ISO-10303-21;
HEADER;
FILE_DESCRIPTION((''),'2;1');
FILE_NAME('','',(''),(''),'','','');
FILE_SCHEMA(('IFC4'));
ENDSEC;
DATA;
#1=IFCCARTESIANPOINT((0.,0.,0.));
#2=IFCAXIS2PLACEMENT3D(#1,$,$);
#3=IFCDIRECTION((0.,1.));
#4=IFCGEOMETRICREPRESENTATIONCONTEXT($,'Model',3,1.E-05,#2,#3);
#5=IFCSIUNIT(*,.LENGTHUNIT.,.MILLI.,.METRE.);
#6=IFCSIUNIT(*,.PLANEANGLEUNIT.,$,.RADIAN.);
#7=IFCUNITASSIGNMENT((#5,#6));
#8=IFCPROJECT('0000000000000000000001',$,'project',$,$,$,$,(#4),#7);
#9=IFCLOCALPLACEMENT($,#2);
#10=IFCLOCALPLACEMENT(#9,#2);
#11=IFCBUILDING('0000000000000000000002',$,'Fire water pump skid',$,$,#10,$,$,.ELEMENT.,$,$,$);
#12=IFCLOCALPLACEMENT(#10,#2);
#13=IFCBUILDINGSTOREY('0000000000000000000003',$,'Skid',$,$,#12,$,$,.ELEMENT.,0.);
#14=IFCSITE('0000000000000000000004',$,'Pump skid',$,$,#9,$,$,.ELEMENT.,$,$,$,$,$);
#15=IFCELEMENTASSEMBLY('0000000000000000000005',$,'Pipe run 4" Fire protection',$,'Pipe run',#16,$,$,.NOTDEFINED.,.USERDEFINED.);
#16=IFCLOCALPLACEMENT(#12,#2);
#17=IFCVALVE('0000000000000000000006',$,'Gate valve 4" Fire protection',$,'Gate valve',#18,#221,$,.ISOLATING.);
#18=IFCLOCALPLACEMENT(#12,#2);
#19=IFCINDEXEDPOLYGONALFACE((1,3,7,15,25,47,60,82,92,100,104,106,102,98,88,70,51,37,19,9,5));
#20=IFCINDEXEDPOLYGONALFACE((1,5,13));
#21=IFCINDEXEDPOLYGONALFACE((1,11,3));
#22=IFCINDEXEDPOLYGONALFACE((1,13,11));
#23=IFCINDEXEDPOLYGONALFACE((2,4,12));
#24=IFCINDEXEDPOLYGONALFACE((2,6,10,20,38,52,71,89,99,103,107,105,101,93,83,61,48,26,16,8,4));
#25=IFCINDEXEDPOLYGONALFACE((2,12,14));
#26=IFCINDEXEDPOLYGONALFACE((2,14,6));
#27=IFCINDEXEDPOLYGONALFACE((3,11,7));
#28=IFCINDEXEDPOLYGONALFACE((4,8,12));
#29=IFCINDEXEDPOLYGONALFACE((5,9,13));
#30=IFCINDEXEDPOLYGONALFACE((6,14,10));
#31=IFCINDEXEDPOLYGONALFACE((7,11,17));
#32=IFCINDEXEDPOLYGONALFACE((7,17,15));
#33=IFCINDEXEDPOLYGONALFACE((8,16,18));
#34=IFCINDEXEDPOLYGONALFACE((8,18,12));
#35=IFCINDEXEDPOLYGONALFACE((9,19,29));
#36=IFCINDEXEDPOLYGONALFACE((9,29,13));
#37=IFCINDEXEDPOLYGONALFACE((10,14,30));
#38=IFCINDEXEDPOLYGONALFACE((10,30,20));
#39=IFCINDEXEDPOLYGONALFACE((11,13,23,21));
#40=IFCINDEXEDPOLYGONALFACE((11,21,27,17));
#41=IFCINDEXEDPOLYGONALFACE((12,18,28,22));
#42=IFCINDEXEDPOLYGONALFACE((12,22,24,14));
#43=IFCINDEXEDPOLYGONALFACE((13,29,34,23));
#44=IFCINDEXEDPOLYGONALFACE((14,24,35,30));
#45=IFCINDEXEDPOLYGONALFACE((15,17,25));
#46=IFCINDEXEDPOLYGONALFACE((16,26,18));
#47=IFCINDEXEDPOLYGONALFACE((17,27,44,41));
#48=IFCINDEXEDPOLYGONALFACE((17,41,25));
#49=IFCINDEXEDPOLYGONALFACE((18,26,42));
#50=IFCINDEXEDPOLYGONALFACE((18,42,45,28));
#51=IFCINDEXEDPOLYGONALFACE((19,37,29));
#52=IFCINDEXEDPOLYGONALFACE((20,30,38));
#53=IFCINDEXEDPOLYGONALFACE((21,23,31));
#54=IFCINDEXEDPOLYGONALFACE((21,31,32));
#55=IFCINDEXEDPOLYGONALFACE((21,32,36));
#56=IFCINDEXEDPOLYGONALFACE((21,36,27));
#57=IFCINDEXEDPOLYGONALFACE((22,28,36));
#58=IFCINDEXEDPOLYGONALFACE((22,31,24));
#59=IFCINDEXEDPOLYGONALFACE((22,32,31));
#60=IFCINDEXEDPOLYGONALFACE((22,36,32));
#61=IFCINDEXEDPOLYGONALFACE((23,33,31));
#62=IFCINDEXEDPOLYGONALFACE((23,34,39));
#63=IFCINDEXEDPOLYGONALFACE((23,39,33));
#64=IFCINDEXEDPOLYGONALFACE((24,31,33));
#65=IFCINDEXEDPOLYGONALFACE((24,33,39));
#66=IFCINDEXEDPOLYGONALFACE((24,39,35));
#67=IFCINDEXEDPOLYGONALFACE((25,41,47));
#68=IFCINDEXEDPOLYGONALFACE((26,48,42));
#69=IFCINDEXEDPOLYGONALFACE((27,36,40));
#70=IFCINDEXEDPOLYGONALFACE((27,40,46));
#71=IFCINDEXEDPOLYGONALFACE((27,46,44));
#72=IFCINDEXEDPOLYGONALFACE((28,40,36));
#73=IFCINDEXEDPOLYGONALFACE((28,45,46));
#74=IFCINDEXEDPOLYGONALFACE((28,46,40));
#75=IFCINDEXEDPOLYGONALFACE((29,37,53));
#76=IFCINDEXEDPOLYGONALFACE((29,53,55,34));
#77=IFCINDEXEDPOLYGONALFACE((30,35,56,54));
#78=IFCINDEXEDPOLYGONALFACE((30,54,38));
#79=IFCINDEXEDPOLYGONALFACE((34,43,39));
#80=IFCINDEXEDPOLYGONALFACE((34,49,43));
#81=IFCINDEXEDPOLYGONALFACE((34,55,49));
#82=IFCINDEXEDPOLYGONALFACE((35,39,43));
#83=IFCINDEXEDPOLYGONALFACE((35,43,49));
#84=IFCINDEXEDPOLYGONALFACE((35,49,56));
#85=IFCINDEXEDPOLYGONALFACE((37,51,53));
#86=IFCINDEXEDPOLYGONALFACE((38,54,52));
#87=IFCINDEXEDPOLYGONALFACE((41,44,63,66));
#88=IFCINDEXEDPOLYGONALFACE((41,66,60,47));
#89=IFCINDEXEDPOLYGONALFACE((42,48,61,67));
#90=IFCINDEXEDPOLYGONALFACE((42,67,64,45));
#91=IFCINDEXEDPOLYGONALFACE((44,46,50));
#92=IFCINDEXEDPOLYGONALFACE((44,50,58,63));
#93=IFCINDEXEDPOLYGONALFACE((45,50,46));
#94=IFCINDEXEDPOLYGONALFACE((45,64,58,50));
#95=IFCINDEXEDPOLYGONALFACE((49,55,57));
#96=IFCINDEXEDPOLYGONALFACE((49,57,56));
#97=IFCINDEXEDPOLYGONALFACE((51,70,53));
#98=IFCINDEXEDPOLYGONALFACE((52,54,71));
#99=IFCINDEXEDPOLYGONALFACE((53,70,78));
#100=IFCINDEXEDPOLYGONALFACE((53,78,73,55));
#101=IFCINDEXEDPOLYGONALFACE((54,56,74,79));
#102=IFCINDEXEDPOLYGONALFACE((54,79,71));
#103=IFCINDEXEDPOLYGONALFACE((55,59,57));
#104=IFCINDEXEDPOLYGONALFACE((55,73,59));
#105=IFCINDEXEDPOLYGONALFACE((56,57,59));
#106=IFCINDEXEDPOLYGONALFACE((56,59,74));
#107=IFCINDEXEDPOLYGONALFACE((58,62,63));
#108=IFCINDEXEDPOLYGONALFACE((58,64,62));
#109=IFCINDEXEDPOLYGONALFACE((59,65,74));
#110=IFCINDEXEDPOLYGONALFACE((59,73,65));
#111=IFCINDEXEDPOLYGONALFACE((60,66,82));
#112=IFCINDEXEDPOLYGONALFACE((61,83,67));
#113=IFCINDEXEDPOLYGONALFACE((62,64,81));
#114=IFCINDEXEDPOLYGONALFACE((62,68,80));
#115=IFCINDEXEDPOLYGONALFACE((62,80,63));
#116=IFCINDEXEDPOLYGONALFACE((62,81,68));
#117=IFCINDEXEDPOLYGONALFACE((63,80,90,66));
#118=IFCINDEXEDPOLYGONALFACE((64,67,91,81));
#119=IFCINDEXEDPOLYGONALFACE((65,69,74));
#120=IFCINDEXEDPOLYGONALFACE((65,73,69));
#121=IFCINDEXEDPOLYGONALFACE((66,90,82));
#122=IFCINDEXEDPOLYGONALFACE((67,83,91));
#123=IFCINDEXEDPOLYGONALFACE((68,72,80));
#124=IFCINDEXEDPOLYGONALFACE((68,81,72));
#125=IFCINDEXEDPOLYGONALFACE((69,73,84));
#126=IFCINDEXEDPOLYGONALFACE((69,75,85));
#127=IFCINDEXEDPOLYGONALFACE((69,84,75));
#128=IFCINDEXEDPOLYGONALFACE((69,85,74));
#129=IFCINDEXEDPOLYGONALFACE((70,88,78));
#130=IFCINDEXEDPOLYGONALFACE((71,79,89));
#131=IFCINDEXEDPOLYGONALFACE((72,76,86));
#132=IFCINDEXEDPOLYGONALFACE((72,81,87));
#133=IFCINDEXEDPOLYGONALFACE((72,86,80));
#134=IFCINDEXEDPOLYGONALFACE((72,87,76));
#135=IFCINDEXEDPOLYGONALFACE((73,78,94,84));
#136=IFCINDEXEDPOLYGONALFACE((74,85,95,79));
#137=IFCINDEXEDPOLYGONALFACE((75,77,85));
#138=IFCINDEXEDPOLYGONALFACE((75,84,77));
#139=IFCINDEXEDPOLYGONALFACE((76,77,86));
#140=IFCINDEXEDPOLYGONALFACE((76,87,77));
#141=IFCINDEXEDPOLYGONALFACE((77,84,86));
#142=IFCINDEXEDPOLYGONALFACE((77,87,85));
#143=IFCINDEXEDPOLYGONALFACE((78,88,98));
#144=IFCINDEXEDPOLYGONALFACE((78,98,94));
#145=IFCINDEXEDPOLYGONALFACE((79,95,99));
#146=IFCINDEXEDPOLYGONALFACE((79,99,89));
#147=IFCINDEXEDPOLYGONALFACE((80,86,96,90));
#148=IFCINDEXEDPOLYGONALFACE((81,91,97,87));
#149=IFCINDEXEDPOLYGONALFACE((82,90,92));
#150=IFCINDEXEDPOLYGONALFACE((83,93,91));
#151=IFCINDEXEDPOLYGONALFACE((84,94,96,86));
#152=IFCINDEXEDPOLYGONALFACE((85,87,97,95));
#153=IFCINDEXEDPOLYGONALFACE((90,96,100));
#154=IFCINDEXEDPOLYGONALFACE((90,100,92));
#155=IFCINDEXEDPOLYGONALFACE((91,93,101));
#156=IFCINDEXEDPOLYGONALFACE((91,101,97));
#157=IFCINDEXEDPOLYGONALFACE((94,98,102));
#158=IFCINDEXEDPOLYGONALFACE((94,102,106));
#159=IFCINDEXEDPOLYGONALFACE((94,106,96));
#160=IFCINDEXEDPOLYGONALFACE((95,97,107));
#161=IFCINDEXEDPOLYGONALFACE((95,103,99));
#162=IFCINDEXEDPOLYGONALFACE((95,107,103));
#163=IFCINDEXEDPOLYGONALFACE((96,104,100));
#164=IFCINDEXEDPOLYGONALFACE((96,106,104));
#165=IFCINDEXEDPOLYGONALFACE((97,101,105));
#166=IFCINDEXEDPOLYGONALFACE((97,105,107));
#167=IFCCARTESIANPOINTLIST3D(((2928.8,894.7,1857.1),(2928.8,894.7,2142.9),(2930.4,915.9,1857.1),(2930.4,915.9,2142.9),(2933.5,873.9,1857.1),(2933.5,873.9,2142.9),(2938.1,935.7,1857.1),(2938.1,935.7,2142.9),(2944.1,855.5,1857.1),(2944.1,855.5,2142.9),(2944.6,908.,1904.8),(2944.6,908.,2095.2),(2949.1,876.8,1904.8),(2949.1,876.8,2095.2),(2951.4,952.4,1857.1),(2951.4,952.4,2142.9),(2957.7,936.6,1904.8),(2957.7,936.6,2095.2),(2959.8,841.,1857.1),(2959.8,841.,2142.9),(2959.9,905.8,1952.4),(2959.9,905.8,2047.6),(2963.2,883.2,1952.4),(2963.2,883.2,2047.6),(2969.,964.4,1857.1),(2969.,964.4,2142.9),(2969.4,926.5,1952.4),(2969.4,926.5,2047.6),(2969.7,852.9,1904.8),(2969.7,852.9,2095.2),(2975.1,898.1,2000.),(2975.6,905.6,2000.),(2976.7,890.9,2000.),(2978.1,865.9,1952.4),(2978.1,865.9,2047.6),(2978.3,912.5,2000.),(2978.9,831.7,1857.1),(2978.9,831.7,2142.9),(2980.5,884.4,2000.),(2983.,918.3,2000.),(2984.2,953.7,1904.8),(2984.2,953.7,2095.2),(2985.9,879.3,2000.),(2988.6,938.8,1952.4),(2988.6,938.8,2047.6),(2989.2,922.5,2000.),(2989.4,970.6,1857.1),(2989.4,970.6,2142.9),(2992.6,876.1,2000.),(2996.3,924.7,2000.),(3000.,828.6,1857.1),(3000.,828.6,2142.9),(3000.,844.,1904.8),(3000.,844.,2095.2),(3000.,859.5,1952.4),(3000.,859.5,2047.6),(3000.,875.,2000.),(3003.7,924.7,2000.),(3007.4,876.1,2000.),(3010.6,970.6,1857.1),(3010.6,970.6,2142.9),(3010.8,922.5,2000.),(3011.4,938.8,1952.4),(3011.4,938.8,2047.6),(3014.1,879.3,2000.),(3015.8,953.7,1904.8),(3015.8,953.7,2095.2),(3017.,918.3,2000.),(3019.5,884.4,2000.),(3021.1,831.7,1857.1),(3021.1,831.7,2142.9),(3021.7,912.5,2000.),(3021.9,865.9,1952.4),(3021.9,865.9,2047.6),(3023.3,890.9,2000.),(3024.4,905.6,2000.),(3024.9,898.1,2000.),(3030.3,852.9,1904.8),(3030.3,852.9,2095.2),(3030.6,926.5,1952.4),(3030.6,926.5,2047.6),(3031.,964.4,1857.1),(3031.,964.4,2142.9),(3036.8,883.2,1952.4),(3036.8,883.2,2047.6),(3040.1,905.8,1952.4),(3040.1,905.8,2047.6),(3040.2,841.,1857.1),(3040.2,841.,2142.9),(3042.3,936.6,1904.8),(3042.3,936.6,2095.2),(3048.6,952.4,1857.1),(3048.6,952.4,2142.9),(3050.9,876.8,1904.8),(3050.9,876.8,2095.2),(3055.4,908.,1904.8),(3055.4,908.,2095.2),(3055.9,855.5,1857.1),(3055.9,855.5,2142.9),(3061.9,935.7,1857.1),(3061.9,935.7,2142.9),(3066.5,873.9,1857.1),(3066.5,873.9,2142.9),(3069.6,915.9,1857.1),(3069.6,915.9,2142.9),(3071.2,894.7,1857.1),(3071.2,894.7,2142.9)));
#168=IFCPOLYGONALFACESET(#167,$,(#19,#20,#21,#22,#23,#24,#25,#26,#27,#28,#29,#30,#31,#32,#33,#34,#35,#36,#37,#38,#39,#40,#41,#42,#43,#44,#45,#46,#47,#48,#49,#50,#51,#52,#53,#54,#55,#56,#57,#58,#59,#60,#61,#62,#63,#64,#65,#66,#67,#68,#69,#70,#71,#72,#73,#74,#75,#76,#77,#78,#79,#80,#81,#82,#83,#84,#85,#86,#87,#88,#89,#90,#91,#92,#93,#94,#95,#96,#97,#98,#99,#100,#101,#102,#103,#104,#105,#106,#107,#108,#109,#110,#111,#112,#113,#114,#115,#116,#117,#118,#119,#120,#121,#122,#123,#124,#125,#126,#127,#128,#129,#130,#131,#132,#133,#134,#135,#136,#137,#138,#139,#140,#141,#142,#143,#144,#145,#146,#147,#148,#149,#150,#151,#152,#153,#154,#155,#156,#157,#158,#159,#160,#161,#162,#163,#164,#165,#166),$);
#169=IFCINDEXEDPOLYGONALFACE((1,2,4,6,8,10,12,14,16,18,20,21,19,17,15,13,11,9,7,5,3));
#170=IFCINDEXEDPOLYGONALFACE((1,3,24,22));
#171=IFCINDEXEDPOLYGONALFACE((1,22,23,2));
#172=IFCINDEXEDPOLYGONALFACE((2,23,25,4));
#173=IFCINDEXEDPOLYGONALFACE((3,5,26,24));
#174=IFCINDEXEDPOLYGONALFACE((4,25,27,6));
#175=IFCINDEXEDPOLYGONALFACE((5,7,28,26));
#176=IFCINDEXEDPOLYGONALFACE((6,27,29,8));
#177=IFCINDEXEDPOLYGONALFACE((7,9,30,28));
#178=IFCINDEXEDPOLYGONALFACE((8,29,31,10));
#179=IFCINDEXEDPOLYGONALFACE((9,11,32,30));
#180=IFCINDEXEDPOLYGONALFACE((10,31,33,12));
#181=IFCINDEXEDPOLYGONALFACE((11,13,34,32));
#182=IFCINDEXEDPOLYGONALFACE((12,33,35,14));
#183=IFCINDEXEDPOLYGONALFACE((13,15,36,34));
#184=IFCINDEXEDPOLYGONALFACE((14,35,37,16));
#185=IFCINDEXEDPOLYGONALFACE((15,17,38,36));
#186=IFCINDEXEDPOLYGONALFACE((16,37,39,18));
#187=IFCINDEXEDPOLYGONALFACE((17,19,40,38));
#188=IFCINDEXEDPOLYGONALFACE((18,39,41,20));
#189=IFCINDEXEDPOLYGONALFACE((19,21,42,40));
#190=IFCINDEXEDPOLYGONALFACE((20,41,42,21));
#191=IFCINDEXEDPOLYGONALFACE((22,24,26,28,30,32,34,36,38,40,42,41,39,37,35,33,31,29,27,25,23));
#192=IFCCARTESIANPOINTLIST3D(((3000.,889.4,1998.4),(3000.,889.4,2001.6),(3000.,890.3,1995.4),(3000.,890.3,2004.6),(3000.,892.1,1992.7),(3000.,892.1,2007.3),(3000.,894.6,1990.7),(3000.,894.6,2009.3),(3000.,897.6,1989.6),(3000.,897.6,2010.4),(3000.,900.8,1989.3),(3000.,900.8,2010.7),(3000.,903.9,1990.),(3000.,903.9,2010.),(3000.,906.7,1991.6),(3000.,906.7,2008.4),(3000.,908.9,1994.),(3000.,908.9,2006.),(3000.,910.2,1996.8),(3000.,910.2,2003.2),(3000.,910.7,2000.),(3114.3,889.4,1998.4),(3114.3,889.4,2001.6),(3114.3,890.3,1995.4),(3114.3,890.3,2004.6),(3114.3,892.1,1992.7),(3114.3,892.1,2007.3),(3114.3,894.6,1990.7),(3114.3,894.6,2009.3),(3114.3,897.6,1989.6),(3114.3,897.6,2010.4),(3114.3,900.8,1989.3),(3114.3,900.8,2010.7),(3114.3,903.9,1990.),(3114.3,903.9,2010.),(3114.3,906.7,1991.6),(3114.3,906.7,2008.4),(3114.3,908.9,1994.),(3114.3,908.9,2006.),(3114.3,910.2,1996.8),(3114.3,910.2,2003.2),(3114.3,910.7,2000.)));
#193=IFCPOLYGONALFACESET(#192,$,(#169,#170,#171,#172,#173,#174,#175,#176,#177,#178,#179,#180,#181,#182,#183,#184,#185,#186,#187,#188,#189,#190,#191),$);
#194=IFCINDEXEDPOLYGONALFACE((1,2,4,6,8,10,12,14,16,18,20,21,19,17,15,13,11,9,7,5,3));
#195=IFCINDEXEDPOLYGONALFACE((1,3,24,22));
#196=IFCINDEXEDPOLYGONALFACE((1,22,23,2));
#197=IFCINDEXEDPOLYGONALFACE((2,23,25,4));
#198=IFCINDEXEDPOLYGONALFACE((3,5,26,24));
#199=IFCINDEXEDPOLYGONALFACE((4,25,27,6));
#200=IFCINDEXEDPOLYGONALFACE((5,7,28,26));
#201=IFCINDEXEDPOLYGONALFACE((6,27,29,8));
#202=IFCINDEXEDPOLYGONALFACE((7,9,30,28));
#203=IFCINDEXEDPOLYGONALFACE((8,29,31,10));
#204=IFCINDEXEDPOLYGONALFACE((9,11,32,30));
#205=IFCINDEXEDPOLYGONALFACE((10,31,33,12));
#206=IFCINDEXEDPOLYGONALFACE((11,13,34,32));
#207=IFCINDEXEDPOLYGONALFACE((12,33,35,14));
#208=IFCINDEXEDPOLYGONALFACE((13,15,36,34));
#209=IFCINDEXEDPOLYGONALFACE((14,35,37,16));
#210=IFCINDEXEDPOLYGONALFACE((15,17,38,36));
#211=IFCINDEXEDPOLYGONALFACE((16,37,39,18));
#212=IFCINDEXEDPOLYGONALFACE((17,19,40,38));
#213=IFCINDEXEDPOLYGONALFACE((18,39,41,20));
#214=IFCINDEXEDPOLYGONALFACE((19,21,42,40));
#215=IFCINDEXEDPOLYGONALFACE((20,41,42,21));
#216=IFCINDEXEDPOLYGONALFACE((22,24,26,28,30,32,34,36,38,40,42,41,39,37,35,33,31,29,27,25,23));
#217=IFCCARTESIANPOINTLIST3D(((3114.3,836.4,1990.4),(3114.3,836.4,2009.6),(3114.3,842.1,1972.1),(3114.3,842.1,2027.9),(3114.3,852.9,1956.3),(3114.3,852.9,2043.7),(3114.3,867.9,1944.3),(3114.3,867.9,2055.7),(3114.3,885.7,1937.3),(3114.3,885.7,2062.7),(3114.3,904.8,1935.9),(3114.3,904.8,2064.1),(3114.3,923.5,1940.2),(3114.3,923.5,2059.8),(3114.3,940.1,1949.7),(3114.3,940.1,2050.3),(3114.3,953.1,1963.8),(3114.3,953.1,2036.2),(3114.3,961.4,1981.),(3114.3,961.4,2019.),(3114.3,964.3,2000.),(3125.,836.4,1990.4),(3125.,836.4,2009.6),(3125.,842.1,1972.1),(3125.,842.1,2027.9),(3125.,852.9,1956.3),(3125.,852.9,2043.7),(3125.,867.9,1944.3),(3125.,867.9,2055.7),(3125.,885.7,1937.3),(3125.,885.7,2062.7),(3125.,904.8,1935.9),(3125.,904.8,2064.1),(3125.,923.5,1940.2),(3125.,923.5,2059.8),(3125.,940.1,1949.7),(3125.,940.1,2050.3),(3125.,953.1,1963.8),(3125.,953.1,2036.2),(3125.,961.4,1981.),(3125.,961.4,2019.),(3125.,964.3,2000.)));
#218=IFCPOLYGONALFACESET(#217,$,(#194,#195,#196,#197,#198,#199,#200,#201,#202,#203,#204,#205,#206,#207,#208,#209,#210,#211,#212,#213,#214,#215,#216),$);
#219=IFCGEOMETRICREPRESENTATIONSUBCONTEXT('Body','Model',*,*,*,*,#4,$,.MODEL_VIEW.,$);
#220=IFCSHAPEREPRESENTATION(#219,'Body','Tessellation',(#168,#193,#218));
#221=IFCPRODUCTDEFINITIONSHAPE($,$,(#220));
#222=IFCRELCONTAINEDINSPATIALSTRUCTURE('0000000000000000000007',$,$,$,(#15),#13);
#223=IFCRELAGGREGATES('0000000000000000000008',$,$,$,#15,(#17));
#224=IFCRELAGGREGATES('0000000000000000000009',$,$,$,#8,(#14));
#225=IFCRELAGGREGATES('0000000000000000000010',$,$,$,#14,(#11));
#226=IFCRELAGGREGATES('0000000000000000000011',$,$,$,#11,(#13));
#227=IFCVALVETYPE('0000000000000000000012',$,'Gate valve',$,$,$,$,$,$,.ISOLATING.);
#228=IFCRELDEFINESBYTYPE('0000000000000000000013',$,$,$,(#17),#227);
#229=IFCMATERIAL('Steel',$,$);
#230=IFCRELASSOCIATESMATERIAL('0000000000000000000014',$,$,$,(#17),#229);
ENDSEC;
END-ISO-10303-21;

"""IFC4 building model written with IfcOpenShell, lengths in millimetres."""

from ifc_helpers import new_model, entity, si_unit, direction, frame, origin, origin_with_axes, origin_2d, place, context, subcontext, project, spatial, circle, extrude, material, type_object, element, aggregate, save


model = new_model("IFC4")

# Units and contexts
model_context = context("Model", 3, precision=1e-05, world=origin(), true_north=direction((0.0, 1.0)))
body_context = subcontext(model_context, "Body", "Model", "MODEL_VIEW")
ifc_project = project(units=[si_unit("LENGTHUNIT", "METRE", prefix="MILLI"), si_unit("PLANEANGLEUNIT", "RADIAN")], contexts=[model_context])

# Site, building, storey
site_placement = place(None, origin())
site = spatial("IfcSite", under=ifc_project, at=site_placement, Name="Pump skid", CompositionType="ELEMENT")
building_placement = place(site_placement, origin())
building = spatial("IfcBuilding", under=site, at=building_placement, Name="Fire water pump skid", CompositionType="ELEMENT")
storey_placement = place(building_placement, origin())
storey = spatial("IfcBuildingStorey", under=building, at=storey_placement, Name="Skid", CompositionType="ELEMENT", Elevation=0.0)

# Element assembly
ifc_material = material(Name="Steel")
assembly_1_placement = place(storey_placement, origin_with_axes())
assembly_1 = element("IfcElementAssembly", 1, at=assembly_1_placement, inside=storey, Name="Pipe run 4\" Fire protection", ObjectType="Pipe run", AssemblyPlace="NOTDEFINED", PredefinedType="USERDEFINED")

# Valve
valve_type_1 = type_object("IfcValveType", Name="Gate valve", PredefinedType="ISOLATING")
valve_1_placement = place(storey_placement, origin_with_axes())
cartesian_point_1 = entity("IfcCartesianPoint", [0.0, 0.0])
valve_1 = element("IfcValve", 2, at=valve_1_placement, type_object=valve_type_1, material=ifc_material, Name="Gate valve 4\" Fire protection", ObjectType="Gate valve", PredefinedType="ISOLATING", context=body_context, shape_type="SweptSolid", body=[
    entity("IfcRevolvedAreaSolid", entity("IfcArbitraryClosedProfileDef", "AREA", None, entity("IfcPolyline", [cartesian_point_1, entity("IfcCartesianPoint", [0.0, 71.4]), entity("IfcCartesianPoint", [142.9, 25.0]), entity("IfcCartesianPoint", [285.8, 71.4]), entity("IfcCartesianPoint", [285.8, 0.0]), cartesian_point_1])), entity("IfcAxis2Placement3D", entity("IfcCartesianPoint", [3000.0, 900.0, 1857.1]), entity("IfcDirection", [1.0, 0.0, 0.0]), entity("IfcDirection", [0.0, 0.0, 1.0])), entity("IfcAxis1Placement", entity("IfcCartesianPoint", [0.0, 0.0, 0.0]), entity("IfcDirection", [1.0, 0.0, 0.0])), 6.283185),
    extrude(circle(Radius=10.7, at=origin_2d()), frame((3000.0, 900.0, 2000.0), z_axis=(1.0, 0.0, 0.0), x_axis=(0.0, 1.0, 0.0)), (0.0, 0.0, 1.0), 114.3),
    extrude(circle(Radius=64.3, at=origin_2d()), frame((3114.3, 900.0, 2000.0), z_axis=(1.0, 0.0, 0.0), x_axis=(0.0, 1.0, 0.0)), (0.0, 0.0, 1.0), 10.7),
])

aggregate(assembly_1, [valve_1])

save(model, "model.ifc")
